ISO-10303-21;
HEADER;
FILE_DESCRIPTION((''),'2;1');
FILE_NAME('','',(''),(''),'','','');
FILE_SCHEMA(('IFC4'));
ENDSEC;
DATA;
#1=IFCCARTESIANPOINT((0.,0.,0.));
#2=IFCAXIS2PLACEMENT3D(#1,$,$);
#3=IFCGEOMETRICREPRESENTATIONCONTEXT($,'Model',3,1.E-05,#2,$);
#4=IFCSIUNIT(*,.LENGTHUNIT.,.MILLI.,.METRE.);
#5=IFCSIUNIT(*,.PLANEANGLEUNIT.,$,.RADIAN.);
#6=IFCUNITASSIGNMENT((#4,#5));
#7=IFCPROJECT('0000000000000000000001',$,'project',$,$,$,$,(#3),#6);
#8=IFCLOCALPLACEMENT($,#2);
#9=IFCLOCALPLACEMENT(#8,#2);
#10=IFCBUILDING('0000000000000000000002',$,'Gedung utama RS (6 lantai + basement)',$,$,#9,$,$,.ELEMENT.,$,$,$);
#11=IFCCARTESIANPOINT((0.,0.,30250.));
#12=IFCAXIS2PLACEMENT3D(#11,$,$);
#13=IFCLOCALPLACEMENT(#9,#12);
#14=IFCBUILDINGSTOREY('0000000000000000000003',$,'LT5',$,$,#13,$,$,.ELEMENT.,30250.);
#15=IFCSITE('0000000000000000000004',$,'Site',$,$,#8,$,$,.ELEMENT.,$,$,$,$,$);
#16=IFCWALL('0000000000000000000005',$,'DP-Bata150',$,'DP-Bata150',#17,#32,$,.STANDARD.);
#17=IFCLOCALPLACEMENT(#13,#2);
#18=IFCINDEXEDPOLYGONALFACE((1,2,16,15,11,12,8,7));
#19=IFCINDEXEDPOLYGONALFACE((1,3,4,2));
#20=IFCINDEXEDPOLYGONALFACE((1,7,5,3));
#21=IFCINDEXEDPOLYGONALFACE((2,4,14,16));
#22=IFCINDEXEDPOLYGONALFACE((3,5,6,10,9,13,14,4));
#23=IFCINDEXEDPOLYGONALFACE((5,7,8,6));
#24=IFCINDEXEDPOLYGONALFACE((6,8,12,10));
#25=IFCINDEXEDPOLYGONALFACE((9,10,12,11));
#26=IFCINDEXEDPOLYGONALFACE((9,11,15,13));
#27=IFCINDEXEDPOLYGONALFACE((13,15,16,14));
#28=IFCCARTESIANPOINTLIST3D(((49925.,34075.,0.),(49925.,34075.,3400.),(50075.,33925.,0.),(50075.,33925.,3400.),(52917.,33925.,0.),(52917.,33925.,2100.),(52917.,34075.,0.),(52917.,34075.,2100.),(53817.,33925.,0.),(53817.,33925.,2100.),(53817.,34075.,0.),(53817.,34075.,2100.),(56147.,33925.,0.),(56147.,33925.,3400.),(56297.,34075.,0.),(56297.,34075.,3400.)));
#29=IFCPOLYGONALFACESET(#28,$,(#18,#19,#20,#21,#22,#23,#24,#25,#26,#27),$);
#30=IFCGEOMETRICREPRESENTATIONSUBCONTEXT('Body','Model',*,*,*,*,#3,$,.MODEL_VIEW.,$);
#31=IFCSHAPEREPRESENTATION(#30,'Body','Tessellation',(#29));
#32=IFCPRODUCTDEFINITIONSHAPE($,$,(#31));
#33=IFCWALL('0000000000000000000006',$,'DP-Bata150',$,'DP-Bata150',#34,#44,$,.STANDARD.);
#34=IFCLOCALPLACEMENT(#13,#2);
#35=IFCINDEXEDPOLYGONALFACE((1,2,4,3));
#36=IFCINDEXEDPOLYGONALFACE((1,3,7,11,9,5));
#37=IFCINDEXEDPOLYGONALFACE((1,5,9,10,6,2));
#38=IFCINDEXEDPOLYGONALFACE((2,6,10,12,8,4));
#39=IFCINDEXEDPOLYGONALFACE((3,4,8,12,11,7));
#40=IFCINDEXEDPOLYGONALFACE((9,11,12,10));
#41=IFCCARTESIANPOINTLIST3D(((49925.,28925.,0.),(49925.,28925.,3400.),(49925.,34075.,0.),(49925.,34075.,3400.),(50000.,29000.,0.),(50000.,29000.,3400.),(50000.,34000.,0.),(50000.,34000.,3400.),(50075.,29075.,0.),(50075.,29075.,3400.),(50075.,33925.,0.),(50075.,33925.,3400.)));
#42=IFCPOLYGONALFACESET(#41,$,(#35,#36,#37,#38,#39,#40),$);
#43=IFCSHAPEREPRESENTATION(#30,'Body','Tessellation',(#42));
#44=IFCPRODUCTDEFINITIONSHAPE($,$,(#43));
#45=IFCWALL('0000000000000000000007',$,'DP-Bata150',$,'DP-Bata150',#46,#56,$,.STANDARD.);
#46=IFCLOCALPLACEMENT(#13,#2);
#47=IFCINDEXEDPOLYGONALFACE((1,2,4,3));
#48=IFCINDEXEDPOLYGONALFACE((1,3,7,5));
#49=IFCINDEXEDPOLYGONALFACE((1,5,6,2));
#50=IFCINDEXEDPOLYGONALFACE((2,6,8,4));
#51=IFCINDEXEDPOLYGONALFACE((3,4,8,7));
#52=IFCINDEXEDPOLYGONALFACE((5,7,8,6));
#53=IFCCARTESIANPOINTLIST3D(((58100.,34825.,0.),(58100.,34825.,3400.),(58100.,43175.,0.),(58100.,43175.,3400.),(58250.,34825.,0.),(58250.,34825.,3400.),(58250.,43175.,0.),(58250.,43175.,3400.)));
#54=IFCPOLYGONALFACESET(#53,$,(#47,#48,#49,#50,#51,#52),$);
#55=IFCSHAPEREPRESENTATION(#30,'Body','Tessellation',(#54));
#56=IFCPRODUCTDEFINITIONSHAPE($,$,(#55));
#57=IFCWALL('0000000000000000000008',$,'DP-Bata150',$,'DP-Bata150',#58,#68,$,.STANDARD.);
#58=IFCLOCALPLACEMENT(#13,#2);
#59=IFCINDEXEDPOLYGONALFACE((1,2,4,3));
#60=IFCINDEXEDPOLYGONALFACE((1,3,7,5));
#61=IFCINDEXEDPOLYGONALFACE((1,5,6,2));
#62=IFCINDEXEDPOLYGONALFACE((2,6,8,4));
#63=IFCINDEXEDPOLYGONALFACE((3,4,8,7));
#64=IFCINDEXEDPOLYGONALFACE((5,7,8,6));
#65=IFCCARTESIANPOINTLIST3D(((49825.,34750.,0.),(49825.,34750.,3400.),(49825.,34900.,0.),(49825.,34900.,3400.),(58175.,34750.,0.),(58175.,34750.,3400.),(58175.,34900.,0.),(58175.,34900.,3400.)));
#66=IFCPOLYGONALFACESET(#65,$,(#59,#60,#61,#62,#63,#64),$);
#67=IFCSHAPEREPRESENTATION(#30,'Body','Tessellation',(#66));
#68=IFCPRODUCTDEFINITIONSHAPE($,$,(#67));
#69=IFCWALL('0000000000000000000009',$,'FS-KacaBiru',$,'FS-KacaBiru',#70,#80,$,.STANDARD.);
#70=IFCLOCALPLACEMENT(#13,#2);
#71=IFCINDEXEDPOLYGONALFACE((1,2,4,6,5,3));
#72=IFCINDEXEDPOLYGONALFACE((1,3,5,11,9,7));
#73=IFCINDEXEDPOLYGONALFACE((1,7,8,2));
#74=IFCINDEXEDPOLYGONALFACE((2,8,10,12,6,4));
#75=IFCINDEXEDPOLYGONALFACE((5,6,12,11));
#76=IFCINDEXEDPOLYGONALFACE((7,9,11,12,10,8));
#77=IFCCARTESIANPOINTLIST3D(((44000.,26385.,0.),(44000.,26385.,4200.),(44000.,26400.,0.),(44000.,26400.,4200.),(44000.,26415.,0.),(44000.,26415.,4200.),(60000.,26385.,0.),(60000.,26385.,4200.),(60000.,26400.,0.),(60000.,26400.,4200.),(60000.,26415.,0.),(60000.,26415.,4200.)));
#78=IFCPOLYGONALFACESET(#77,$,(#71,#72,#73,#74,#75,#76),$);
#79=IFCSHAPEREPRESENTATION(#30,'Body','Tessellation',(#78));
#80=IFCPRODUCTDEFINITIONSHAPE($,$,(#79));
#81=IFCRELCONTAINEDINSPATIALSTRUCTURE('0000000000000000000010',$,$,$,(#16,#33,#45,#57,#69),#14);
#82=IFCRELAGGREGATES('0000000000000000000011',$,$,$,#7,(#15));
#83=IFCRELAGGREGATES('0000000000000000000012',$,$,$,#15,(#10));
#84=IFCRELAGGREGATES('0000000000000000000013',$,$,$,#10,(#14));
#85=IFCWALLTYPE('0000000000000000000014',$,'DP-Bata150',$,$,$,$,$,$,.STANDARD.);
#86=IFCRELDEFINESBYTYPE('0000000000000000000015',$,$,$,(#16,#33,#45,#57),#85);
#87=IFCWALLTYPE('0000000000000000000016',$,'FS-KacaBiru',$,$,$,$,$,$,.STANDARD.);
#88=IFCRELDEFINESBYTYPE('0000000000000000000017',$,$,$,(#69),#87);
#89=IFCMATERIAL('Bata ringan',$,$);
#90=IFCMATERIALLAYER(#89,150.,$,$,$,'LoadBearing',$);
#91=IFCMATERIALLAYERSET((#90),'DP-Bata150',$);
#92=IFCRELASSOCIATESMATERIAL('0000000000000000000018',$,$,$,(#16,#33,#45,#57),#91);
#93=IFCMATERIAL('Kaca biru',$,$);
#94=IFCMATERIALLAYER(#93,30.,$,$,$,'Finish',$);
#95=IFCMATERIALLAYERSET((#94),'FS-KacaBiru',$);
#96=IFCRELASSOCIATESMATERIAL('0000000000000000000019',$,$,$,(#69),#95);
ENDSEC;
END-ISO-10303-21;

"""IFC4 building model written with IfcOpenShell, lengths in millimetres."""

from ifc_helpers import new_model, si_unit, frame, frame_2d, origin, place, context, subcontext, project, spatial, polyline, rectangle, outline, extrude, material, layer, layer_set, layer_usage, type_object, element, save


model = new_model("IFC4")

# Units and contexts
model_context = context("Model", 3, precision=1e-05, world=origin())
body_context = subcontext(model_context, "Body", "Model", "MODEL_VIEW")
ifc_project = project(units=[si_unit("LENGTHUNIT", "METRE", prefix="MILLI"), si_unit("PLANEANGLEUNIT", "RADIAN")], contexts=[model_context])

# Site, building, storey
site_placement = place(None, origin())
site = spatial("IfcSite", under=ifc_project, at=site_placement, Name="Site", CompositionType="ELEMENT")
building_placement = place(site_placement, origin())
building = spatial("IfcBuilding", under=site, at=building_placement, Name="Gedung utama RS (6 lantai + basement)", CompositionType="ELEMENT")
storey_placement = place(building_placement, frame((0.0, 0.0, 30250.0)))
storey = spatial("IfcBuildingStorey", under=building, at=storey_placement, Name="LT5", CompositionType="ELEMENT", Elevation=30250.0)

# Shared definitions
ifc_material_1 = material(Name="Bata ringan")
ifc_layer_1 = layer(ifc_material_1, 150.0, Category="LoadBearing")
ifc_layer_set_1 = layer_set([ifc_layer_1], Name="DP-Bata150")
ifc_layer_usage_1 = layer_usage(ifc_layer_set_1, "AXIS2", "NEGATIVE", 75.0)
wall_type_1 = type_object("IfcWallType", Name="DP-Bata150", PredefinedType="STANDARD")

# Wall, opening
wall_1_placement = place(storey_placement, frame((56222.0, 34000.0, 0.0), z_axis=(0.0, 0.0, 1.0), x_axis=(-1.0, 0.0, 0.0)))
wall_1 = element("IfcWall", 1, at=wall_1_placement, inside=storey, type_object=wall_type_1, material=ifc_layer_usage_1, Name="DP-Bata150", ObjectType="DP-Bata150", PredefinedType="STANDARD", context=body_context, shape_type="SweptSolid", body=[
    extrude(outline(polyline([(-75.0, -75.0), (0.0, 0.0), (75.0, 75.0), (6147.0, 75.0), (6222.0, 0.0), (6297.0, -75.0), (-75.0, -75.0)])), origin(), (0.0, 0.0, 1.0), 3400.0),
])
opening_1_placement = place(wall_1_placement, frame((2405.0, 0.0, 0.0), z_axis=(0.0, 0.0, 1.0), x_axis=(1.0, 0.0, 0.0)))
element("IfcOpeningElement", 2, at=opening_1_placement, cuts=wall_1, PredefinedType="OPENING", context=body_context, shape_type="SweptSolid", body=[
    extrude(rectangle(XDim=900.0, YDim=170.0, at=frame_2d((450.0, 0.0))), origin(), (0.0, 0.0, 1.0), 2100.0),
])

# Walls
wall_2_placement = place(storey_placement, frame((50000.0, 34000.0, 0.0), z_axis=(0.0, 0.0, 1.0), x_axis=(0.0, -1.0, 0.0)))
element("IfcWall", 3, at=wall_2_placement, inside=storey, type_object=wall_type_1, material=ifc_layer_usage_1, Name="DP-Bata150", ObjectType="DP-Bata150", PredefinedType="STANDARD", context=body_context, shape_type="SweptSolid", body=[
    extrude(outline(polyline([(-75.0, -75.0), (0.0, 0.0), (75.0, 75.0), (4925.0, 75.0), (5000.0, 0.0), (5075.0, -75.0), (-75.0, -75.0)])), origin(), (0.0, 0.0, 1.0), 3400.0),
])
for number, where, z_axis, x_axis, name in (
    (4, (58175.0, 34825.0, 0.0), (0.0, 0.0, 1.0), (0.0, 1.0, 0.0), "DP-Bata150"),
    (5, (49825.0, 34825.0, 0.0), (0.0, 0.0, 1.0), (1.0, 0.0, 0.0), "DP-Bata150"),
):
    element("IfcWall", number, at=place(storey_placement, frame(where, z_axis=z_axis, x_axis=x_axis)), inside=storey, type_object=wall_type_1, material=ifc_layer_usage_1, Name=name, ObjectType="DP-Bata150", PredefinedType="STANDARD", context=body_context, shape_type="SweptSolid", body=[
        extrude(outline(polyline([(0.0, -75.0), (0.0, 75.0), (8350.0, 75.0), (8350.0, -75.0), (0.0, -75.0)])), origin(), (0.0, 0.0, 1.0), 3400.0),
    ])
ifc_material_2 = material(Name="Kaca biru")
ifc_layer_2 = layer(ifc_material_2, 30.0, Category="Finish")
ifc_layer_set_2 = layer_set([ifc_layer_2], Name="FS-KacaBiru")
ifc_layer_usage_2 = layer_usage(ifc_layer_set_2, "AXIS2", "NEGATIVE", 15.0)
wall_type_2 = type_object("IfcWallType", Name="FS-KacaBiru", PredefinedType="STANDARD")
wall_3_placement = place(storey_placement, frame((60000.0, 26400.0, 0.0), z_axis=(0.0, 0.0, 1.0), x_axis=(-1.0, 0.0, 0.0)))
element("IfcWall", 6, at=wall_3_placement, inside=storey, type_object=wall_type_2, material=ifc_layer_usage_2, Name="FS-KacaBiru", ObjectType="FS-KacaBiru", PredefinedType="STANDARD", context=body_context, shape_type="SweptSolid", body=[
    extrude(outline(polyline([(0.0, -15.0), (0.0, 0.0), (0.0, 15.0), (16000.0, 15.0), (16000.0, 0.0), (16000.0, -15.0), (0.0, -15.0)])), origin(), (0.0, 0.0, 1.0), 4200.0),
])

save(model, "model.ifc")
